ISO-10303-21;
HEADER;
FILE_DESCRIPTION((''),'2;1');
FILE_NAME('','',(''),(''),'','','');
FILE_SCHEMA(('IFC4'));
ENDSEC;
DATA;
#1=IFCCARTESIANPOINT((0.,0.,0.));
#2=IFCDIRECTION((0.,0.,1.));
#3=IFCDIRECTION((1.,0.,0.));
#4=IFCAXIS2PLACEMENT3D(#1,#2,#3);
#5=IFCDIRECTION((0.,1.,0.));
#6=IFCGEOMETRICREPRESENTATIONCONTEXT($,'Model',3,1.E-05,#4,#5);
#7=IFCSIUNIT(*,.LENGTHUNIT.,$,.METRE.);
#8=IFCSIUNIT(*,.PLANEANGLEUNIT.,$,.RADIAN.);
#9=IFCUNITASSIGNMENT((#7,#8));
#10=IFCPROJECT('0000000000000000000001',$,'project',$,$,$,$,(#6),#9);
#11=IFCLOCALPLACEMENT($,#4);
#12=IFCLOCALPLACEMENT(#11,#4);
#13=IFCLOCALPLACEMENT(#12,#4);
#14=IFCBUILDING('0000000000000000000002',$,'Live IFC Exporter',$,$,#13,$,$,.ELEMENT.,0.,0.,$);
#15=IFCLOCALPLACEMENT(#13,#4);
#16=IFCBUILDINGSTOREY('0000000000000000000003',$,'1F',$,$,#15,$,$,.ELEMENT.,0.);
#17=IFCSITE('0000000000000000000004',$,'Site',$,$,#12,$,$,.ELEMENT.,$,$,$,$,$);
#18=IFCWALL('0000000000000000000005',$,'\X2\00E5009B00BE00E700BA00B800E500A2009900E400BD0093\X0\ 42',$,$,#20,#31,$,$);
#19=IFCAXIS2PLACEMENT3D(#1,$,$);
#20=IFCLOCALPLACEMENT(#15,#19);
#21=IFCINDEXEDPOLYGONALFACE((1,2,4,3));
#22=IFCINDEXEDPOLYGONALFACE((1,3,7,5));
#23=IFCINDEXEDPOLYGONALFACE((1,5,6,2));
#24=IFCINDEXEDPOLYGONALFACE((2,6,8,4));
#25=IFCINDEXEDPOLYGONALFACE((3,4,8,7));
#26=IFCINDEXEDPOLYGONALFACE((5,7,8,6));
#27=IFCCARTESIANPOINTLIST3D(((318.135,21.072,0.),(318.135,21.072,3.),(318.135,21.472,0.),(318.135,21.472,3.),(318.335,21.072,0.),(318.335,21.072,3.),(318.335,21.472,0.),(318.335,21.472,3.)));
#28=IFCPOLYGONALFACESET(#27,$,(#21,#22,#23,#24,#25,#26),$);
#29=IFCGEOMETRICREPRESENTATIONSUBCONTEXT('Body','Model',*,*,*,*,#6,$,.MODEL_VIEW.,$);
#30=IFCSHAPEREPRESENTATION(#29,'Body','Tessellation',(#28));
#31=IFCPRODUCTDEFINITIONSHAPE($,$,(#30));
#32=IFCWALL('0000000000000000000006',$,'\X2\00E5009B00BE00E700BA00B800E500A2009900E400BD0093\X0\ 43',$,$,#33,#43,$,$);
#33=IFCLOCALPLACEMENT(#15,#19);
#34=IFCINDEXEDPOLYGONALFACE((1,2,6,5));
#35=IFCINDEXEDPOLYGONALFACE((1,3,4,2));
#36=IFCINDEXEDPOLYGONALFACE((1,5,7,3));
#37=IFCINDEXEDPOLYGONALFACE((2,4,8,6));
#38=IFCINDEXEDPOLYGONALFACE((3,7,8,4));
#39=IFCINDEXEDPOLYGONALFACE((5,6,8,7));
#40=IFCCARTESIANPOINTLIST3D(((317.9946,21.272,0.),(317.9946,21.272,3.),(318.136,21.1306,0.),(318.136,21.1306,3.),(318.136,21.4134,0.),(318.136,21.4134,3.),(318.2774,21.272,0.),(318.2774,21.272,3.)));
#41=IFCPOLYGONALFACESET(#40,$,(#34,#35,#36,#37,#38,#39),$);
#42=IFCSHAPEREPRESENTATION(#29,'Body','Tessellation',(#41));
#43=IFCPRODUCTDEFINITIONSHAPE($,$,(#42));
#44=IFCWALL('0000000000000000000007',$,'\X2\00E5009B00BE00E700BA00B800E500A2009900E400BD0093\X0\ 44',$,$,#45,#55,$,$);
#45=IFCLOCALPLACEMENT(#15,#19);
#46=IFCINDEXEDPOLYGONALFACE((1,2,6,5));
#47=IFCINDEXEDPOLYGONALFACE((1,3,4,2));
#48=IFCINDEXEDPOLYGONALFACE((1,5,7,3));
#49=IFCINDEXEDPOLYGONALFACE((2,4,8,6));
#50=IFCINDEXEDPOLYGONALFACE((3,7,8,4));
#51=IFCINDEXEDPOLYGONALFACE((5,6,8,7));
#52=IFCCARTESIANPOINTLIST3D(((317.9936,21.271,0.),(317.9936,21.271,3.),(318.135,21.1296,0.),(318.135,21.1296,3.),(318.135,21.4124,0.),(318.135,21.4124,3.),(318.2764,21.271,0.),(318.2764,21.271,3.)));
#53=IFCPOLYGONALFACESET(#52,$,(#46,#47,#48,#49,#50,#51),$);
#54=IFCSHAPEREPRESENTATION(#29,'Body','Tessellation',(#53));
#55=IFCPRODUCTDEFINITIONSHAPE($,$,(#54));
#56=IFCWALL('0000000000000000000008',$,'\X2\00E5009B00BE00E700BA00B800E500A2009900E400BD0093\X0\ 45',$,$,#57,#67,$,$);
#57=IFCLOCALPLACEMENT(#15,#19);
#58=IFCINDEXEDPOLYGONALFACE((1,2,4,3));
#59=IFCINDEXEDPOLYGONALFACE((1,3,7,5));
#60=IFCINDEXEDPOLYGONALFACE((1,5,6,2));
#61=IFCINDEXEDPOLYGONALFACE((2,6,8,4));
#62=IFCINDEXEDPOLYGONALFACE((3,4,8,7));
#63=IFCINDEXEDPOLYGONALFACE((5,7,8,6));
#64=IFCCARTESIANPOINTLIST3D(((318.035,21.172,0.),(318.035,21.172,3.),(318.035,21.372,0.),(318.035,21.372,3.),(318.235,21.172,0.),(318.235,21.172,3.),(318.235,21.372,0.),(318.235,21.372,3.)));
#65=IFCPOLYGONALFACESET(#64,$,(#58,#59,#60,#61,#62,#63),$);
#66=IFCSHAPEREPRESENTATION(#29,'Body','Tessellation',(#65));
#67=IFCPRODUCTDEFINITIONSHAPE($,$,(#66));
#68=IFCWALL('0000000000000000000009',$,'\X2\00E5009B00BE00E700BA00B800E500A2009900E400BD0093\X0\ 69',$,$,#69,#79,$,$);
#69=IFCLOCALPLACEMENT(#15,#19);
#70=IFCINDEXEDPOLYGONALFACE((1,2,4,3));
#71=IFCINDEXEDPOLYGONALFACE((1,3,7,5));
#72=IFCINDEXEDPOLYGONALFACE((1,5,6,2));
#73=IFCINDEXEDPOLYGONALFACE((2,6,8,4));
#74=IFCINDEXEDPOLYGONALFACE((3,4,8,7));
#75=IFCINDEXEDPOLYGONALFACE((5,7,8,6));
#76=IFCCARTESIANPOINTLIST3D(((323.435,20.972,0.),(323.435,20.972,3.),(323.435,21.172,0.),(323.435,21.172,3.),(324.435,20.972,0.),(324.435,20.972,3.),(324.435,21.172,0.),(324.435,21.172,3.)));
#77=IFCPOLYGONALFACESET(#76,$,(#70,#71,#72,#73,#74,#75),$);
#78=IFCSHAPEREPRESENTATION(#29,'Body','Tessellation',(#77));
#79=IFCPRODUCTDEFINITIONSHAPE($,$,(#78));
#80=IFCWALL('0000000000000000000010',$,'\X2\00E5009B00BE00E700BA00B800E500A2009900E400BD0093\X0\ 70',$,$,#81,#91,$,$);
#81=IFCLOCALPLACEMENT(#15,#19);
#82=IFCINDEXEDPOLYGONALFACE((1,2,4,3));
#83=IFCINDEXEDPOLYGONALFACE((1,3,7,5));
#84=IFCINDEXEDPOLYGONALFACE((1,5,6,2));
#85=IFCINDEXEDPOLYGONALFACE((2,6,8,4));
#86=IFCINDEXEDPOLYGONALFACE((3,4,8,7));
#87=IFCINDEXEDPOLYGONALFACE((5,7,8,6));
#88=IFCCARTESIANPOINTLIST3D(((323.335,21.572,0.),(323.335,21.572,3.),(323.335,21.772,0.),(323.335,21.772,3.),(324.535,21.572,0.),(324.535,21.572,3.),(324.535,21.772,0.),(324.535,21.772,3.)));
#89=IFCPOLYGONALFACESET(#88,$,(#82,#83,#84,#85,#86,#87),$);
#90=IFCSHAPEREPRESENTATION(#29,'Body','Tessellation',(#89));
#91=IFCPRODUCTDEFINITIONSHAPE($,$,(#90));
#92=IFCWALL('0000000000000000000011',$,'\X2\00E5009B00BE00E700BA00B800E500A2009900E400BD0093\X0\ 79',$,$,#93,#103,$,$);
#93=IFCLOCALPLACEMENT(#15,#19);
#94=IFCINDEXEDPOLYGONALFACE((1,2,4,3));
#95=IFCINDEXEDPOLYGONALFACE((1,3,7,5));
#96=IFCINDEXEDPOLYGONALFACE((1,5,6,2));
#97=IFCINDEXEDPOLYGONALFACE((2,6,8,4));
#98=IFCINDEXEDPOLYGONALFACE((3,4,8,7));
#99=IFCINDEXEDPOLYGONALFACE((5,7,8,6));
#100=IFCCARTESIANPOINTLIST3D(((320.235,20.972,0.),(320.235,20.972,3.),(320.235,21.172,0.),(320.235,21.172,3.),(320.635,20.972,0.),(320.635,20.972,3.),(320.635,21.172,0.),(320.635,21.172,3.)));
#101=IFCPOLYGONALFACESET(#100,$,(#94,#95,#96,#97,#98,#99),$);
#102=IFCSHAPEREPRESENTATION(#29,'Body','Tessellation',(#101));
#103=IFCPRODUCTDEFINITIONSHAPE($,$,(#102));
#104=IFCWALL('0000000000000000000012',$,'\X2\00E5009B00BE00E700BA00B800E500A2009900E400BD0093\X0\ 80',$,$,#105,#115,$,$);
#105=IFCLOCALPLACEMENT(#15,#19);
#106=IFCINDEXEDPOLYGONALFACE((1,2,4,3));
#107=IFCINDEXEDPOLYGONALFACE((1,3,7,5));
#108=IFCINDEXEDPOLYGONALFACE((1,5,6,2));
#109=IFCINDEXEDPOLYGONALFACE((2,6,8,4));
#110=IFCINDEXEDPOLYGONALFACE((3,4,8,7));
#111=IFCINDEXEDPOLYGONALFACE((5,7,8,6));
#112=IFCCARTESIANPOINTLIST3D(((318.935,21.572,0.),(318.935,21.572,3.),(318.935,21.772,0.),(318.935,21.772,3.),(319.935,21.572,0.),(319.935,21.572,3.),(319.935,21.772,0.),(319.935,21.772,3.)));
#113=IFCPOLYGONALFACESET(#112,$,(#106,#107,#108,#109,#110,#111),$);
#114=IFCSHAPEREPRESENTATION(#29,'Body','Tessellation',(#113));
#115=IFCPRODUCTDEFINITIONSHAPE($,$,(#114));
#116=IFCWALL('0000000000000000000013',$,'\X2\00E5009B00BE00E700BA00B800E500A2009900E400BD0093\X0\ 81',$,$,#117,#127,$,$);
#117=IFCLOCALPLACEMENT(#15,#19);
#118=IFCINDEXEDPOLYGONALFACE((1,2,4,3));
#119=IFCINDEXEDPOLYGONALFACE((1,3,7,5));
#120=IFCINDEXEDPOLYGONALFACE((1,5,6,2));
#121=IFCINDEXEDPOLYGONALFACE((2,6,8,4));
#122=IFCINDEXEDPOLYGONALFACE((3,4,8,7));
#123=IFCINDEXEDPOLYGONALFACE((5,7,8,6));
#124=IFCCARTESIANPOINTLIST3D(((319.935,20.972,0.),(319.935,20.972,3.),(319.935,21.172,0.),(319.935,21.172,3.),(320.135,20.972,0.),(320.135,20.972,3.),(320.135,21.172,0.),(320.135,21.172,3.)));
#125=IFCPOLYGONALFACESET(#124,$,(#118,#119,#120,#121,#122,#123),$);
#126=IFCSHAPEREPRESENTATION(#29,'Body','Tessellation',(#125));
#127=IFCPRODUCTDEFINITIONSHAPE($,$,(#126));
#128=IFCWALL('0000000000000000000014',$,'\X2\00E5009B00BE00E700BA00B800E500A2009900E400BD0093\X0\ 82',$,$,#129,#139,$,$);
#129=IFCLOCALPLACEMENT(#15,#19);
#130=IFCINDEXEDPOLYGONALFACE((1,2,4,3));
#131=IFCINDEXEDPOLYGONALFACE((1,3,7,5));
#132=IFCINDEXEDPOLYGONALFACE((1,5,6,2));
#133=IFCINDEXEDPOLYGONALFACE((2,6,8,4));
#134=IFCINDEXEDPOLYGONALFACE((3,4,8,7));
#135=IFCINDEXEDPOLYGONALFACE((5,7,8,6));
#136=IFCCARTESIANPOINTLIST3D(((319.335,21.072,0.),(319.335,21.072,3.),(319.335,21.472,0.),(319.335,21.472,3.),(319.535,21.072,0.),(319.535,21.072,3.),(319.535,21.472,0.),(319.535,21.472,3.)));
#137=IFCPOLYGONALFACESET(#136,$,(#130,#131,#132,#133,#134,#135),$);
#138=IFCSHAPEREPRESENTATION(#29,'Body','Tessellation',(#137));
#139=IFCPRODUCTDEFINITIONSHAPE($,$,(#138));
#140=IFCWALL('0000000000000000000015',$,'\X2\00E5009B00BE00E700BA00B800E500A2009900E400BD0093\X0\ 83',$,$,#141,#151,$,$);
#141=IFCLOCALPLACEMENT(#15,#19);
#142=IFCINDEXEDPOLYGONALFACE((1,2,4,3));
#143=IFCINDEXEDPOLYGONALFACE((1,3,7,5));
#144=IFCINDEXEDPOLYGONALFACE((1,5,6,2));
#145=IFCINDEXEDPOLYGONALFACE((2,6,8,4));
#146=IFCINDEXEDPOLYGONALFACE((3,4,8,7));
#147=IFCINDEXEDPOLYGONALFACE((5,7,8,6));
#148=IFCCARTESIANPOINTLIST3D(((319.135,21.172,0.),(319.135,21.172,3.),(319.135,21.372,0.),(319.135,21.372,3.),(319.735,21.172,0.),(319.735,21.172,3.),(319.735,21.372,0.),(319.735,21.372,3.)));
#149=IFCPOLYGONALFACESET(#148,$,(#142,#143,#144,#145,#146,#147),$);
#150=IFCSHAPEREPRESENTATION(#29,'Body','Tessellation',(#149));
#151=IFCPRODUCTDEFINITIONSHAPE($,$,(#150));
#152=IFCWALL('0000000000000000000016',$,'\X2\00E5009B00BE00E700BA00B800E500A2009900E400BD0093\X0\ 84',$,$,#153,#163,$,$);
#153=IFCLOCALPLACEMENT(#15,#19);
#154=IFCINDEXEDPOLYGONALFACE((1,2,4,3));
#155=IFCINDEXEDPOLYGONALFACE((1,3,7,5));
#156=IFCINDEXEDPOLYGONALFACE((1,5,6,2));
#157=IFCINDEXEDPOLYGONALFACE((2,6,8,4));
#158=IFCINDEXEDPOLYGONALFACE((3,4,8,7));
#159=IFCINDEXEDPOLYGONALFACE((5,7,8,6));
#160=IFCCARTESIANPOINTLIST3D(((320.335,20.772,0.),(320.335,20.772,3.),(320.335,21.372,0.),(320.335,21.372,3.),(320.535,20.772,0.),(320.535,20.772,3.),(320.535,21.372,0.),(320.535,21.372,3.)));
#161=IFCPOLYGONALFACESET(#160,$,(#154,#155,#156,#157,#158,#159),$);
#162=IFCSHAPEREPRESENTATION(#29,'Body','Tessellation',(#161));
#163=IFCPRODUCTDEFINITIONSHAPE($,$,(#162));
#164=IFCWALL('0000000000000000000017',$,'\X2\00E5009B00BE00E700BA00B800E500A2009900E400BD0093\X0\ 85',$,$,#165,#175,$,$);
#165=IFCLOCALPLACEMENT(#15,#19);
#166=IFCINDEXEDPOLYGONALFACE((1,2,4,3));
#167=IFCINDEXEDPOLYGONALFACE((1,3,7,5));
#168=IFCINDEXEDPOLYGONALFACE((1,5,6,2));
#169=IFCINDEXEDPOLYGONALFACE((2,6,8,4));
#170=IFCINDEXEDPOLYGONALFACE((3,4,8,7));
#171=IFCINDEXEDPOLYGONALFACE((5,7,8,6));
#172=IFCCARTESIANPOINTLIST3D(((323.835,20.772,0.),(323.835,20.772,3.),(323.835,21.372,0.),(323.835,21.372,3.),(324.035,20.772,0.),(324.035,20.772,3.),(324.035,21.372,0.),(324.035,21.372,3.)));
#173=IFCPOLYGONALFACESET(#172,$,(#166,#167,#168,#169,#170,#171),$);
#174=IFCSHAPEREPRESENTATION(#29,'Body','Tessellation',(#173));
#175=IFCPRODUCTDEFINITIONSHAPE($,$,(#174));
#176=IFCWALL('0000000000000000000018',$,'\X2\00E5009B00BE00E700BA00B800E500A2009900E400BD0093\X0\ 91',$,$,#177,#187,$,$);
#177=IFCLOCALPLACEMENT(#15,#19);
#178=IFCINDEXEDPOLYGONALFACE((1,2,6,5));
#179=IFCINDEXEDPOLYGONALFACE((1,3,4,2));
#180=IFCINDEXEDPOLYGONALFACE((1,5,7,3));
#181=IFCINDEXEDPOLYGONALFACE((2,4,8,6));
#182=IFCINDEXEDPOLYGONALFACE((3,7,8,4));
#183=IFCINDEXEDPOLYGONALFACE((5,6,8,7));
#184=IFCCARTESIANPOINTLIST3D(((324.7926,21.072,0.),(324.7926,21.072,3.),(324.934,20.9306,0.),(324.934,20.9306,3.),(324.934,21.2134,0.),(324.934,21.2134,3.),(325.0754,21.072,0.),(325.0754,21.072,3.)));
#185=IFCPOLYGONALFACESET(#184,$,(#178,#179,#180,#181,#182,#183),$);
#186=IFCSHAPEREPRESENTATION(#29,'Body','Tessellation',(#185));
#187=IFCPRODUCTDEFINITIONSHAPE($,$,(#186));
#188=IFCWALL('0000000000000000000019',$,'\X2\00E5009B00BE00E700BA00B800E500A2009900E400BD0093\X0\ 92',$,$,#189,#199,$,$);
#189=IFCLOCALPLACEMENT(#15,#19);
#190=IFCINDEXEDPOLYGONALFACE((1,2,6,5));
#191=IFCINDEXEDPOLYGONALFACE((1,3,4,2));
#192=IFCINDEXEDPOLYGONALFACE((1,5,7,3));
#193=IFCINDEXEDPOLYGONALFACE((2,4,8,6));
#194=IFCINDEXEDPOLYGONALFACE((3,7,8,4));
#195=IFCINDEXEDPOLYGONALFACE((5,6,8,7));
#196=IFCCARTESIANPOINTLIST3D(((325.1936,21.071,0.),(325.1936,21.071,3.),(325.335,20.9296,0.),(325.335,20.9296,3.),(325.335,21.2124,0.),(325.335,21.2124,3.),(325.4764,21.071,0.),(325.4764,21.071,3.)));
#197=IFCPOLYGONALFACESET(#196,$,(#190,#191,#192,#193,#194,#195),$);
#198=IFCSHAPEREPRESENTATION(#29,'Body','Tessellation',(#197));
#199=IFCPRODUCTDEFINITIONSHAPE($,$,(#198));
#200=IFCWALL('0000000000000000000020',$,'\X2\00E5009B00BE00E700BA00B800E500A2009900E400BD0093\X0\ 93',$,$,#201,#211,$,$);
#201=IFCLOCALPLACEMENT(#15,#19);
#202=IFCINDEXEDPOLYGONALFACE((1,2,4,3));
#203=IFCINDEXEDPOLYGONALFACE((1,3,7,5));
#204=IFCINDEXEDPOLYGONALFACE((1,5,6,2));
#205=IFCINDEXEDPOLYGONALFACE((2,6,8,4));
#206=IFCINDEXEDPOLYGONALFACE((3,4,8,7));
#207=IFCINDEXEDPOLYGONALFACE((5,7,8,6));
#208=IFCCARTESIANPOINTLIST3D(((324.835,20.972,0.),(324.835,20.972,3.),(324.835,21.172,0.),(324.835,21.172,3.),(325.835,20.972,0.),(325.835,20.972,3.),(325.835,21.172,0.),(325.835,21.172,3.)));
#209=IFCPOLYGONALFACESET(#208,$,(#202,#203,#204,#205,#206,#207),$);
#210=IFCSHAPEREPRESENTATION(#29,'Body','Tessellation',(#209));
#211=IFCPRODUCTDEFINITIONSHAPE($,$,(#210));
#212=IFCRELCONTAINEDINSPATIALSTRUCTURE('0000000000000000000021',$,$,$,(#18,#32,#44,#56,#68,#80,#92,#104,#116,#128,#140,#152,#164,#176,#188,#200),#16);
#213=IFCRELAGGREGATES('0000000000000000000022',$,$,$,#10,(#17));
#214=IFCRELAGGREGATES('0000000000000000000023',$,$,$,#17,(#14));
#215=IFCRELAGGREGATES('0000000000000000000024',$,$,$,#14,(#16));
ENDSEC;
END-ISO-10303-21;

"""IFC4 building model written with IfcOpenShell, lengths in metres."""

from ifc_helpers import new_model, si_unit, direction, frame, frame_2d, origin_with_axes, place, context, subcontext, project, spatial, rectangle, extrude, element, save


model = new_model("IFC4")

# Units and contexts
model_context = context("Model", 3, precision=1e-05, world=origin_with_axes(), true_north=direction((0.0, 1.0, 0.0)))
body_context = subcontext(model_context, "Body", "Model", "MODEL_VIEW")
ifc_project = project(units=[si_unit("LENGTHUNIT", "METRE"), si_unit("PLANEANGLEUNIT", "RADIAN")], contexts=[model_context])

# Site, building, storey
placement = place(None, origin_with_axes())
site_placement = place(placement, origin_with_axes())
site = spatial("IfcSite", under=ifc_project, at=site_placement, Name="Site", CompositionType="ELEMENT")
building_placement = place(site_placement, origin_with_axes())
building = spatial("IfcBuilding", under=site, at=building_placement, Name="Live IFC Exporter", CompositionType="ELEMENT", ElevationOfRefHeight=0.0, ElevationOfTerrain=0.0)
storey_placement = place(building_placement, origin_with_axes())
storey = spatial("IfcBuildingStorey", under=building, at=storey_placement, Name="1F", CompositionType="ELEMENT", Elevation=0.0)

# Walls
wall_1_placement = place(storey_placement, frame((318.235, 21.272, 0.0), z_axis=(0.0, 0.0, 1.0), x_axis=(0.0, 1.0, 0.0)))
element("IfcWall", 1, at=wall_1_placement, inside=storey, Name="å\u009b¾çº¸å¢\u0099ä½\u0093 42", context=body_context, shape_type="SweptSolid", body=[
    extrude(rectangle(XDim=0.4, YDim=0.2, at=frame_2d((0.0, 0.0), x_axis=(1.0, 0.0, 0.0))), frame((0.0, 0.0, 0.0), z_axis=(0.0, 0.0, 1.0)), (0.0, 0.0, 1.0), 3.0),
])
for number, where, z_axis, x_axis, name in (
    (2, (318.136, 21.272, 0.0), (0.0, 0.0, 1.0), (-0.707107, -0.707107, 0.0), "å\u009b¾çº¸å¢\u0099ä½\u0093 43"),
    (3, (318.135, 21.271, 0.0), (0.0, 0.0, 1.0), (0.707107, 0.707107, 0.0), "å\u009b¾çº¸å¢\u0099ä½\u0093 44"),
    (4, (318.135, 21.272, 0.0), (0.0, 0.0, 1.0), (1.0, 0.0, 0.0), "å\u009b¾çº¸å¢\u0099ä½\u0093 45"),
):
    element("IfcWall", number, at=place(storey_placement, frame(where, z_axis=z_axis, x_axis=x_axis)), inside=storey, Name=name, context=body_context, shape_type="SweptSolid", body=[
        extrude(rectangle(XDim=0.2, YDim=0.2, at=frame_2d((0.0, 0.0), x_axis=(1.0, 0.0, 0.0))), frame((0.0, 0.0, 0.0), z_axis=(0.0, 0.0, 1.0)), (0.0, 0.0, 1.0), 3.0),
    ])
wall_2_placement = place(storey_placement, frame((323.935, 21.072, 0.0), z_axis=(0.0, 0.0, 1.0), x_axis=(1.0, 0.0, 0.0)))
element("IfcWall", 5, at=wall_2_placement, inside=storey, Name="å\u009b¾çº¸å¢\u0099ä½\u0093 69", context=body_context, shape_type="SweptSolid", body=[
    extrude(rectangle(XDim=1.0, YDim=0.2, at=frame_2d((0.0, 0.0), x_axis=(1.0, 0.0, 0.0))), frame((0.0, 0.0, 0.0), z_axis=(0.0, 0.0, 1.0)), (0.0, 0.0, 1.0), 3.0),
])
wall_3_placement = place(storey_placement, frame((323.935, 21.672, 0.0), z_axis=(0.0, 0.0, 1.0), x_axis=(1.0, 0.0, 0.0)))
element("IfcWall", 6, at=wall_3_placement, inside=storey, Name="å\u009b¾çº¸å¢\u0099ä½\u0093 70", context=body_context, shape_type="SweptSolid", body=[
    extrude(rectangle(XDim=1.2, YDim=0.2, at=frame_2d((0.0, 0.0), x_axis=(1.0, 0.0, 0.0))), frame((0.0, 0.0, 0.0), z_axis=(0.0, 0.0, 1.0)), (0.0, 0.0, 1.0), 3.0),
])
wall_4_placement = place(storey_placement, frame((320.435, 21.072, 0.0), z_axis=(0.0, 0.0, 1.0), x_axis=(-1.0, 0.0, 0.0)))
element("IfcWall", 7, at=wall_4_placement, inside=storey, Name="å\u009b¾çº¸å¢\u0099ä½\u0093 79", context=body_context, shape_type="SweptSolid", body=[
    extrude(rectangle(XDim=0.4, YDim=0.2, at=frame_2d((0.0, 0.0), x_axis=(1.0, 0.0, 0.0))), frame((0.0, 0.0, 0.0), z_axis=(0.0, 0.0, 1.0)), (0.0, 0.0, 1.0), 3.0),
])
wall_5_placement = place(storey_placement, frame((319.435, 21.672, 0.0), z_axis=(0.0, 0.0, 1.0), x_axis=(1.0, 0.0, 0.0)))
element("IfcWall", 8, at=wall_5_placement, inside=storey, Name="å\u009b¾çº¸å¢\u0099ä½\u0093 80", context=body_context, shape_type="SweptSolid", body=[
    extrude(rectangle(XDim=1.0, YDim=0.2, at=frame_2d((0.0, 0.0), x_axis=(1.0, 0.0, 0.0))), frame((0.0, 0.0, 0.0), z_axis=(0.0, 0.0, 1.0)), (0.0, 0.0, 1.0), 3.0),
])
wall_6_placement = place(storey_placement, frame((320.035, 21.072, 0.0), z_axis=(0.0, 0.0, 1.0), x_axis=(0.0, 1.0, 0.0)))
element("IfcWall", 9, at=wall_6_placement, inside=storey, Name="å\u009b¾çº¸å¢\u0099ä½\u0093 81", context=body_context, shape_type="SweptSolid", body=[
    extrude(rectangle(XDim=0.2, YDim=0.2, at=frame_2d((0.0, 0.0), x_axis=(1.0, 0.0, 0.0))), frame((0.0, 0.0, 0.0), z_axis=(0.0, 0.0, 1.0)), (0.0, 0.0, 1.0), 3.0),
])
wall_7_placement = place(storey_placement, frame((319.435, 21.272, 0.0), z_axis=(0.0, 0.0, 1.0), x_axis=(0.0, 1.0, 0.0)))
element("IfcWall", 10, at=wall_7_placement, inside=storey, Name="å\u009b¾çº¸å¢\u0099ä½\u0093 82", context=body_context, shape_type="SweptSolid", body=[
    extrude(rectangle(XDim=0.4, YDim=0.2, at=frame_2d((0.0, 0.0), x_axis=(1.0, 0.0, 0.0))), frame((0.0, 0.0, 0.0), z_axis=(0.0, 0.0, 1.0)), (0.0, 0.0, 1.0), 3.0),
])
for number, where, z_axis, x_axis, name in (
    (11, (319.435, 21.272, 0.0), (0.0, 0.0, 1.0), (1.0, 0.0, 0.0), "å\u009b¾çº¸å¢\u0099ä½\u0093 83"),
    (12, (320.435, 21.072, 0.0), (0.0, 0.0, 1.0), (0.0, 1.0, 0.0), "å\u009b¾çº¸å¢\u0099ä½\u0093 84"),
    (13, (323.935, 21.072, 0.0), (0.0, 0.0, 1.0), (0.0, 1.0, 0.0), "å\u009b¾çº¸å¢\u0099ä½\u0093 85"),
):
    element("IfcWall", number, at=place(storey_placement, frame(where, z_axis=z_axis, x_axis=x_axis)), inside=storey, Name=name, context=body_context, shape_type="SweptSolid", body=[
        extrude(rectangle(XDim=0.6, YDim=0.2, at=frame_2d((0.0, 0.0), x_axis=(1.0, 0.0, 0.0))), frame((0.0, 0.0, 0.0), z_axis=(0.0, 0.0, 1.0)), (0.0, 0.0, 1.0), 3.0),
    ])
for number, where, z_axis, x_axis, name in (
    (14, (324.934, 21.072, 0.0), (0.0, 0.0, 1.0), (0.707107, -0.707107, 0.0), "å\u009b¾çº¸å¢\u0099ä½\u0093 91"),
    (15, (325.335, 21.071, 0.0), (0.0, 0.0, 1.0), (0.707107, 0.707107, 0.0), "å\u009b¾çº¸å¢\u0099ä½\u0093 92"),
):
    element("IfcWall", number, at=place(storey_placement, frame(where, z_axis=z_axis, x_axis=x_axis)), inside=storey, Name=name, context=body_context, shape_type="SweptSolid", body=[
        extrude(rectangle(XDim=0.2, YDim=0.2, at=frame_2d((0.0, 0.0), x_axis=(1.0, 0.0, 0.0))), frame((0.0, 0.0, 0.0), z_axis=(0.0, 0.0, 1.0)), (0.0, 0.0, 1.0), 3.0),
    ])
wall_8_placement = place(storey_placement, frame((325.335, 21.072, 0.0), z_axis=(0.0, 0.0, 1.0), x_axis=(1.0, 0.0, 0.0)))
element("IfcWall", 16, at=wall_8_placement, inside=storey, Name="å\u009b¾çº¸å¢\u0099ä½\u0093 93", context=body_context, shape_type="SweptSolid", body=[
    extrude(rectangle(XDim=1.0, YDim=0.2, at=frame_2d((0.0, 0.0), x_axis=(1.0, 0.0, 0.0))), frame((0.0, 0.0, 0.0), z_axis=(0.0, 0.0, 1.0)), (0.0, 0.0, 1.0), 3.0),
])

save(model, "model.ifc")
